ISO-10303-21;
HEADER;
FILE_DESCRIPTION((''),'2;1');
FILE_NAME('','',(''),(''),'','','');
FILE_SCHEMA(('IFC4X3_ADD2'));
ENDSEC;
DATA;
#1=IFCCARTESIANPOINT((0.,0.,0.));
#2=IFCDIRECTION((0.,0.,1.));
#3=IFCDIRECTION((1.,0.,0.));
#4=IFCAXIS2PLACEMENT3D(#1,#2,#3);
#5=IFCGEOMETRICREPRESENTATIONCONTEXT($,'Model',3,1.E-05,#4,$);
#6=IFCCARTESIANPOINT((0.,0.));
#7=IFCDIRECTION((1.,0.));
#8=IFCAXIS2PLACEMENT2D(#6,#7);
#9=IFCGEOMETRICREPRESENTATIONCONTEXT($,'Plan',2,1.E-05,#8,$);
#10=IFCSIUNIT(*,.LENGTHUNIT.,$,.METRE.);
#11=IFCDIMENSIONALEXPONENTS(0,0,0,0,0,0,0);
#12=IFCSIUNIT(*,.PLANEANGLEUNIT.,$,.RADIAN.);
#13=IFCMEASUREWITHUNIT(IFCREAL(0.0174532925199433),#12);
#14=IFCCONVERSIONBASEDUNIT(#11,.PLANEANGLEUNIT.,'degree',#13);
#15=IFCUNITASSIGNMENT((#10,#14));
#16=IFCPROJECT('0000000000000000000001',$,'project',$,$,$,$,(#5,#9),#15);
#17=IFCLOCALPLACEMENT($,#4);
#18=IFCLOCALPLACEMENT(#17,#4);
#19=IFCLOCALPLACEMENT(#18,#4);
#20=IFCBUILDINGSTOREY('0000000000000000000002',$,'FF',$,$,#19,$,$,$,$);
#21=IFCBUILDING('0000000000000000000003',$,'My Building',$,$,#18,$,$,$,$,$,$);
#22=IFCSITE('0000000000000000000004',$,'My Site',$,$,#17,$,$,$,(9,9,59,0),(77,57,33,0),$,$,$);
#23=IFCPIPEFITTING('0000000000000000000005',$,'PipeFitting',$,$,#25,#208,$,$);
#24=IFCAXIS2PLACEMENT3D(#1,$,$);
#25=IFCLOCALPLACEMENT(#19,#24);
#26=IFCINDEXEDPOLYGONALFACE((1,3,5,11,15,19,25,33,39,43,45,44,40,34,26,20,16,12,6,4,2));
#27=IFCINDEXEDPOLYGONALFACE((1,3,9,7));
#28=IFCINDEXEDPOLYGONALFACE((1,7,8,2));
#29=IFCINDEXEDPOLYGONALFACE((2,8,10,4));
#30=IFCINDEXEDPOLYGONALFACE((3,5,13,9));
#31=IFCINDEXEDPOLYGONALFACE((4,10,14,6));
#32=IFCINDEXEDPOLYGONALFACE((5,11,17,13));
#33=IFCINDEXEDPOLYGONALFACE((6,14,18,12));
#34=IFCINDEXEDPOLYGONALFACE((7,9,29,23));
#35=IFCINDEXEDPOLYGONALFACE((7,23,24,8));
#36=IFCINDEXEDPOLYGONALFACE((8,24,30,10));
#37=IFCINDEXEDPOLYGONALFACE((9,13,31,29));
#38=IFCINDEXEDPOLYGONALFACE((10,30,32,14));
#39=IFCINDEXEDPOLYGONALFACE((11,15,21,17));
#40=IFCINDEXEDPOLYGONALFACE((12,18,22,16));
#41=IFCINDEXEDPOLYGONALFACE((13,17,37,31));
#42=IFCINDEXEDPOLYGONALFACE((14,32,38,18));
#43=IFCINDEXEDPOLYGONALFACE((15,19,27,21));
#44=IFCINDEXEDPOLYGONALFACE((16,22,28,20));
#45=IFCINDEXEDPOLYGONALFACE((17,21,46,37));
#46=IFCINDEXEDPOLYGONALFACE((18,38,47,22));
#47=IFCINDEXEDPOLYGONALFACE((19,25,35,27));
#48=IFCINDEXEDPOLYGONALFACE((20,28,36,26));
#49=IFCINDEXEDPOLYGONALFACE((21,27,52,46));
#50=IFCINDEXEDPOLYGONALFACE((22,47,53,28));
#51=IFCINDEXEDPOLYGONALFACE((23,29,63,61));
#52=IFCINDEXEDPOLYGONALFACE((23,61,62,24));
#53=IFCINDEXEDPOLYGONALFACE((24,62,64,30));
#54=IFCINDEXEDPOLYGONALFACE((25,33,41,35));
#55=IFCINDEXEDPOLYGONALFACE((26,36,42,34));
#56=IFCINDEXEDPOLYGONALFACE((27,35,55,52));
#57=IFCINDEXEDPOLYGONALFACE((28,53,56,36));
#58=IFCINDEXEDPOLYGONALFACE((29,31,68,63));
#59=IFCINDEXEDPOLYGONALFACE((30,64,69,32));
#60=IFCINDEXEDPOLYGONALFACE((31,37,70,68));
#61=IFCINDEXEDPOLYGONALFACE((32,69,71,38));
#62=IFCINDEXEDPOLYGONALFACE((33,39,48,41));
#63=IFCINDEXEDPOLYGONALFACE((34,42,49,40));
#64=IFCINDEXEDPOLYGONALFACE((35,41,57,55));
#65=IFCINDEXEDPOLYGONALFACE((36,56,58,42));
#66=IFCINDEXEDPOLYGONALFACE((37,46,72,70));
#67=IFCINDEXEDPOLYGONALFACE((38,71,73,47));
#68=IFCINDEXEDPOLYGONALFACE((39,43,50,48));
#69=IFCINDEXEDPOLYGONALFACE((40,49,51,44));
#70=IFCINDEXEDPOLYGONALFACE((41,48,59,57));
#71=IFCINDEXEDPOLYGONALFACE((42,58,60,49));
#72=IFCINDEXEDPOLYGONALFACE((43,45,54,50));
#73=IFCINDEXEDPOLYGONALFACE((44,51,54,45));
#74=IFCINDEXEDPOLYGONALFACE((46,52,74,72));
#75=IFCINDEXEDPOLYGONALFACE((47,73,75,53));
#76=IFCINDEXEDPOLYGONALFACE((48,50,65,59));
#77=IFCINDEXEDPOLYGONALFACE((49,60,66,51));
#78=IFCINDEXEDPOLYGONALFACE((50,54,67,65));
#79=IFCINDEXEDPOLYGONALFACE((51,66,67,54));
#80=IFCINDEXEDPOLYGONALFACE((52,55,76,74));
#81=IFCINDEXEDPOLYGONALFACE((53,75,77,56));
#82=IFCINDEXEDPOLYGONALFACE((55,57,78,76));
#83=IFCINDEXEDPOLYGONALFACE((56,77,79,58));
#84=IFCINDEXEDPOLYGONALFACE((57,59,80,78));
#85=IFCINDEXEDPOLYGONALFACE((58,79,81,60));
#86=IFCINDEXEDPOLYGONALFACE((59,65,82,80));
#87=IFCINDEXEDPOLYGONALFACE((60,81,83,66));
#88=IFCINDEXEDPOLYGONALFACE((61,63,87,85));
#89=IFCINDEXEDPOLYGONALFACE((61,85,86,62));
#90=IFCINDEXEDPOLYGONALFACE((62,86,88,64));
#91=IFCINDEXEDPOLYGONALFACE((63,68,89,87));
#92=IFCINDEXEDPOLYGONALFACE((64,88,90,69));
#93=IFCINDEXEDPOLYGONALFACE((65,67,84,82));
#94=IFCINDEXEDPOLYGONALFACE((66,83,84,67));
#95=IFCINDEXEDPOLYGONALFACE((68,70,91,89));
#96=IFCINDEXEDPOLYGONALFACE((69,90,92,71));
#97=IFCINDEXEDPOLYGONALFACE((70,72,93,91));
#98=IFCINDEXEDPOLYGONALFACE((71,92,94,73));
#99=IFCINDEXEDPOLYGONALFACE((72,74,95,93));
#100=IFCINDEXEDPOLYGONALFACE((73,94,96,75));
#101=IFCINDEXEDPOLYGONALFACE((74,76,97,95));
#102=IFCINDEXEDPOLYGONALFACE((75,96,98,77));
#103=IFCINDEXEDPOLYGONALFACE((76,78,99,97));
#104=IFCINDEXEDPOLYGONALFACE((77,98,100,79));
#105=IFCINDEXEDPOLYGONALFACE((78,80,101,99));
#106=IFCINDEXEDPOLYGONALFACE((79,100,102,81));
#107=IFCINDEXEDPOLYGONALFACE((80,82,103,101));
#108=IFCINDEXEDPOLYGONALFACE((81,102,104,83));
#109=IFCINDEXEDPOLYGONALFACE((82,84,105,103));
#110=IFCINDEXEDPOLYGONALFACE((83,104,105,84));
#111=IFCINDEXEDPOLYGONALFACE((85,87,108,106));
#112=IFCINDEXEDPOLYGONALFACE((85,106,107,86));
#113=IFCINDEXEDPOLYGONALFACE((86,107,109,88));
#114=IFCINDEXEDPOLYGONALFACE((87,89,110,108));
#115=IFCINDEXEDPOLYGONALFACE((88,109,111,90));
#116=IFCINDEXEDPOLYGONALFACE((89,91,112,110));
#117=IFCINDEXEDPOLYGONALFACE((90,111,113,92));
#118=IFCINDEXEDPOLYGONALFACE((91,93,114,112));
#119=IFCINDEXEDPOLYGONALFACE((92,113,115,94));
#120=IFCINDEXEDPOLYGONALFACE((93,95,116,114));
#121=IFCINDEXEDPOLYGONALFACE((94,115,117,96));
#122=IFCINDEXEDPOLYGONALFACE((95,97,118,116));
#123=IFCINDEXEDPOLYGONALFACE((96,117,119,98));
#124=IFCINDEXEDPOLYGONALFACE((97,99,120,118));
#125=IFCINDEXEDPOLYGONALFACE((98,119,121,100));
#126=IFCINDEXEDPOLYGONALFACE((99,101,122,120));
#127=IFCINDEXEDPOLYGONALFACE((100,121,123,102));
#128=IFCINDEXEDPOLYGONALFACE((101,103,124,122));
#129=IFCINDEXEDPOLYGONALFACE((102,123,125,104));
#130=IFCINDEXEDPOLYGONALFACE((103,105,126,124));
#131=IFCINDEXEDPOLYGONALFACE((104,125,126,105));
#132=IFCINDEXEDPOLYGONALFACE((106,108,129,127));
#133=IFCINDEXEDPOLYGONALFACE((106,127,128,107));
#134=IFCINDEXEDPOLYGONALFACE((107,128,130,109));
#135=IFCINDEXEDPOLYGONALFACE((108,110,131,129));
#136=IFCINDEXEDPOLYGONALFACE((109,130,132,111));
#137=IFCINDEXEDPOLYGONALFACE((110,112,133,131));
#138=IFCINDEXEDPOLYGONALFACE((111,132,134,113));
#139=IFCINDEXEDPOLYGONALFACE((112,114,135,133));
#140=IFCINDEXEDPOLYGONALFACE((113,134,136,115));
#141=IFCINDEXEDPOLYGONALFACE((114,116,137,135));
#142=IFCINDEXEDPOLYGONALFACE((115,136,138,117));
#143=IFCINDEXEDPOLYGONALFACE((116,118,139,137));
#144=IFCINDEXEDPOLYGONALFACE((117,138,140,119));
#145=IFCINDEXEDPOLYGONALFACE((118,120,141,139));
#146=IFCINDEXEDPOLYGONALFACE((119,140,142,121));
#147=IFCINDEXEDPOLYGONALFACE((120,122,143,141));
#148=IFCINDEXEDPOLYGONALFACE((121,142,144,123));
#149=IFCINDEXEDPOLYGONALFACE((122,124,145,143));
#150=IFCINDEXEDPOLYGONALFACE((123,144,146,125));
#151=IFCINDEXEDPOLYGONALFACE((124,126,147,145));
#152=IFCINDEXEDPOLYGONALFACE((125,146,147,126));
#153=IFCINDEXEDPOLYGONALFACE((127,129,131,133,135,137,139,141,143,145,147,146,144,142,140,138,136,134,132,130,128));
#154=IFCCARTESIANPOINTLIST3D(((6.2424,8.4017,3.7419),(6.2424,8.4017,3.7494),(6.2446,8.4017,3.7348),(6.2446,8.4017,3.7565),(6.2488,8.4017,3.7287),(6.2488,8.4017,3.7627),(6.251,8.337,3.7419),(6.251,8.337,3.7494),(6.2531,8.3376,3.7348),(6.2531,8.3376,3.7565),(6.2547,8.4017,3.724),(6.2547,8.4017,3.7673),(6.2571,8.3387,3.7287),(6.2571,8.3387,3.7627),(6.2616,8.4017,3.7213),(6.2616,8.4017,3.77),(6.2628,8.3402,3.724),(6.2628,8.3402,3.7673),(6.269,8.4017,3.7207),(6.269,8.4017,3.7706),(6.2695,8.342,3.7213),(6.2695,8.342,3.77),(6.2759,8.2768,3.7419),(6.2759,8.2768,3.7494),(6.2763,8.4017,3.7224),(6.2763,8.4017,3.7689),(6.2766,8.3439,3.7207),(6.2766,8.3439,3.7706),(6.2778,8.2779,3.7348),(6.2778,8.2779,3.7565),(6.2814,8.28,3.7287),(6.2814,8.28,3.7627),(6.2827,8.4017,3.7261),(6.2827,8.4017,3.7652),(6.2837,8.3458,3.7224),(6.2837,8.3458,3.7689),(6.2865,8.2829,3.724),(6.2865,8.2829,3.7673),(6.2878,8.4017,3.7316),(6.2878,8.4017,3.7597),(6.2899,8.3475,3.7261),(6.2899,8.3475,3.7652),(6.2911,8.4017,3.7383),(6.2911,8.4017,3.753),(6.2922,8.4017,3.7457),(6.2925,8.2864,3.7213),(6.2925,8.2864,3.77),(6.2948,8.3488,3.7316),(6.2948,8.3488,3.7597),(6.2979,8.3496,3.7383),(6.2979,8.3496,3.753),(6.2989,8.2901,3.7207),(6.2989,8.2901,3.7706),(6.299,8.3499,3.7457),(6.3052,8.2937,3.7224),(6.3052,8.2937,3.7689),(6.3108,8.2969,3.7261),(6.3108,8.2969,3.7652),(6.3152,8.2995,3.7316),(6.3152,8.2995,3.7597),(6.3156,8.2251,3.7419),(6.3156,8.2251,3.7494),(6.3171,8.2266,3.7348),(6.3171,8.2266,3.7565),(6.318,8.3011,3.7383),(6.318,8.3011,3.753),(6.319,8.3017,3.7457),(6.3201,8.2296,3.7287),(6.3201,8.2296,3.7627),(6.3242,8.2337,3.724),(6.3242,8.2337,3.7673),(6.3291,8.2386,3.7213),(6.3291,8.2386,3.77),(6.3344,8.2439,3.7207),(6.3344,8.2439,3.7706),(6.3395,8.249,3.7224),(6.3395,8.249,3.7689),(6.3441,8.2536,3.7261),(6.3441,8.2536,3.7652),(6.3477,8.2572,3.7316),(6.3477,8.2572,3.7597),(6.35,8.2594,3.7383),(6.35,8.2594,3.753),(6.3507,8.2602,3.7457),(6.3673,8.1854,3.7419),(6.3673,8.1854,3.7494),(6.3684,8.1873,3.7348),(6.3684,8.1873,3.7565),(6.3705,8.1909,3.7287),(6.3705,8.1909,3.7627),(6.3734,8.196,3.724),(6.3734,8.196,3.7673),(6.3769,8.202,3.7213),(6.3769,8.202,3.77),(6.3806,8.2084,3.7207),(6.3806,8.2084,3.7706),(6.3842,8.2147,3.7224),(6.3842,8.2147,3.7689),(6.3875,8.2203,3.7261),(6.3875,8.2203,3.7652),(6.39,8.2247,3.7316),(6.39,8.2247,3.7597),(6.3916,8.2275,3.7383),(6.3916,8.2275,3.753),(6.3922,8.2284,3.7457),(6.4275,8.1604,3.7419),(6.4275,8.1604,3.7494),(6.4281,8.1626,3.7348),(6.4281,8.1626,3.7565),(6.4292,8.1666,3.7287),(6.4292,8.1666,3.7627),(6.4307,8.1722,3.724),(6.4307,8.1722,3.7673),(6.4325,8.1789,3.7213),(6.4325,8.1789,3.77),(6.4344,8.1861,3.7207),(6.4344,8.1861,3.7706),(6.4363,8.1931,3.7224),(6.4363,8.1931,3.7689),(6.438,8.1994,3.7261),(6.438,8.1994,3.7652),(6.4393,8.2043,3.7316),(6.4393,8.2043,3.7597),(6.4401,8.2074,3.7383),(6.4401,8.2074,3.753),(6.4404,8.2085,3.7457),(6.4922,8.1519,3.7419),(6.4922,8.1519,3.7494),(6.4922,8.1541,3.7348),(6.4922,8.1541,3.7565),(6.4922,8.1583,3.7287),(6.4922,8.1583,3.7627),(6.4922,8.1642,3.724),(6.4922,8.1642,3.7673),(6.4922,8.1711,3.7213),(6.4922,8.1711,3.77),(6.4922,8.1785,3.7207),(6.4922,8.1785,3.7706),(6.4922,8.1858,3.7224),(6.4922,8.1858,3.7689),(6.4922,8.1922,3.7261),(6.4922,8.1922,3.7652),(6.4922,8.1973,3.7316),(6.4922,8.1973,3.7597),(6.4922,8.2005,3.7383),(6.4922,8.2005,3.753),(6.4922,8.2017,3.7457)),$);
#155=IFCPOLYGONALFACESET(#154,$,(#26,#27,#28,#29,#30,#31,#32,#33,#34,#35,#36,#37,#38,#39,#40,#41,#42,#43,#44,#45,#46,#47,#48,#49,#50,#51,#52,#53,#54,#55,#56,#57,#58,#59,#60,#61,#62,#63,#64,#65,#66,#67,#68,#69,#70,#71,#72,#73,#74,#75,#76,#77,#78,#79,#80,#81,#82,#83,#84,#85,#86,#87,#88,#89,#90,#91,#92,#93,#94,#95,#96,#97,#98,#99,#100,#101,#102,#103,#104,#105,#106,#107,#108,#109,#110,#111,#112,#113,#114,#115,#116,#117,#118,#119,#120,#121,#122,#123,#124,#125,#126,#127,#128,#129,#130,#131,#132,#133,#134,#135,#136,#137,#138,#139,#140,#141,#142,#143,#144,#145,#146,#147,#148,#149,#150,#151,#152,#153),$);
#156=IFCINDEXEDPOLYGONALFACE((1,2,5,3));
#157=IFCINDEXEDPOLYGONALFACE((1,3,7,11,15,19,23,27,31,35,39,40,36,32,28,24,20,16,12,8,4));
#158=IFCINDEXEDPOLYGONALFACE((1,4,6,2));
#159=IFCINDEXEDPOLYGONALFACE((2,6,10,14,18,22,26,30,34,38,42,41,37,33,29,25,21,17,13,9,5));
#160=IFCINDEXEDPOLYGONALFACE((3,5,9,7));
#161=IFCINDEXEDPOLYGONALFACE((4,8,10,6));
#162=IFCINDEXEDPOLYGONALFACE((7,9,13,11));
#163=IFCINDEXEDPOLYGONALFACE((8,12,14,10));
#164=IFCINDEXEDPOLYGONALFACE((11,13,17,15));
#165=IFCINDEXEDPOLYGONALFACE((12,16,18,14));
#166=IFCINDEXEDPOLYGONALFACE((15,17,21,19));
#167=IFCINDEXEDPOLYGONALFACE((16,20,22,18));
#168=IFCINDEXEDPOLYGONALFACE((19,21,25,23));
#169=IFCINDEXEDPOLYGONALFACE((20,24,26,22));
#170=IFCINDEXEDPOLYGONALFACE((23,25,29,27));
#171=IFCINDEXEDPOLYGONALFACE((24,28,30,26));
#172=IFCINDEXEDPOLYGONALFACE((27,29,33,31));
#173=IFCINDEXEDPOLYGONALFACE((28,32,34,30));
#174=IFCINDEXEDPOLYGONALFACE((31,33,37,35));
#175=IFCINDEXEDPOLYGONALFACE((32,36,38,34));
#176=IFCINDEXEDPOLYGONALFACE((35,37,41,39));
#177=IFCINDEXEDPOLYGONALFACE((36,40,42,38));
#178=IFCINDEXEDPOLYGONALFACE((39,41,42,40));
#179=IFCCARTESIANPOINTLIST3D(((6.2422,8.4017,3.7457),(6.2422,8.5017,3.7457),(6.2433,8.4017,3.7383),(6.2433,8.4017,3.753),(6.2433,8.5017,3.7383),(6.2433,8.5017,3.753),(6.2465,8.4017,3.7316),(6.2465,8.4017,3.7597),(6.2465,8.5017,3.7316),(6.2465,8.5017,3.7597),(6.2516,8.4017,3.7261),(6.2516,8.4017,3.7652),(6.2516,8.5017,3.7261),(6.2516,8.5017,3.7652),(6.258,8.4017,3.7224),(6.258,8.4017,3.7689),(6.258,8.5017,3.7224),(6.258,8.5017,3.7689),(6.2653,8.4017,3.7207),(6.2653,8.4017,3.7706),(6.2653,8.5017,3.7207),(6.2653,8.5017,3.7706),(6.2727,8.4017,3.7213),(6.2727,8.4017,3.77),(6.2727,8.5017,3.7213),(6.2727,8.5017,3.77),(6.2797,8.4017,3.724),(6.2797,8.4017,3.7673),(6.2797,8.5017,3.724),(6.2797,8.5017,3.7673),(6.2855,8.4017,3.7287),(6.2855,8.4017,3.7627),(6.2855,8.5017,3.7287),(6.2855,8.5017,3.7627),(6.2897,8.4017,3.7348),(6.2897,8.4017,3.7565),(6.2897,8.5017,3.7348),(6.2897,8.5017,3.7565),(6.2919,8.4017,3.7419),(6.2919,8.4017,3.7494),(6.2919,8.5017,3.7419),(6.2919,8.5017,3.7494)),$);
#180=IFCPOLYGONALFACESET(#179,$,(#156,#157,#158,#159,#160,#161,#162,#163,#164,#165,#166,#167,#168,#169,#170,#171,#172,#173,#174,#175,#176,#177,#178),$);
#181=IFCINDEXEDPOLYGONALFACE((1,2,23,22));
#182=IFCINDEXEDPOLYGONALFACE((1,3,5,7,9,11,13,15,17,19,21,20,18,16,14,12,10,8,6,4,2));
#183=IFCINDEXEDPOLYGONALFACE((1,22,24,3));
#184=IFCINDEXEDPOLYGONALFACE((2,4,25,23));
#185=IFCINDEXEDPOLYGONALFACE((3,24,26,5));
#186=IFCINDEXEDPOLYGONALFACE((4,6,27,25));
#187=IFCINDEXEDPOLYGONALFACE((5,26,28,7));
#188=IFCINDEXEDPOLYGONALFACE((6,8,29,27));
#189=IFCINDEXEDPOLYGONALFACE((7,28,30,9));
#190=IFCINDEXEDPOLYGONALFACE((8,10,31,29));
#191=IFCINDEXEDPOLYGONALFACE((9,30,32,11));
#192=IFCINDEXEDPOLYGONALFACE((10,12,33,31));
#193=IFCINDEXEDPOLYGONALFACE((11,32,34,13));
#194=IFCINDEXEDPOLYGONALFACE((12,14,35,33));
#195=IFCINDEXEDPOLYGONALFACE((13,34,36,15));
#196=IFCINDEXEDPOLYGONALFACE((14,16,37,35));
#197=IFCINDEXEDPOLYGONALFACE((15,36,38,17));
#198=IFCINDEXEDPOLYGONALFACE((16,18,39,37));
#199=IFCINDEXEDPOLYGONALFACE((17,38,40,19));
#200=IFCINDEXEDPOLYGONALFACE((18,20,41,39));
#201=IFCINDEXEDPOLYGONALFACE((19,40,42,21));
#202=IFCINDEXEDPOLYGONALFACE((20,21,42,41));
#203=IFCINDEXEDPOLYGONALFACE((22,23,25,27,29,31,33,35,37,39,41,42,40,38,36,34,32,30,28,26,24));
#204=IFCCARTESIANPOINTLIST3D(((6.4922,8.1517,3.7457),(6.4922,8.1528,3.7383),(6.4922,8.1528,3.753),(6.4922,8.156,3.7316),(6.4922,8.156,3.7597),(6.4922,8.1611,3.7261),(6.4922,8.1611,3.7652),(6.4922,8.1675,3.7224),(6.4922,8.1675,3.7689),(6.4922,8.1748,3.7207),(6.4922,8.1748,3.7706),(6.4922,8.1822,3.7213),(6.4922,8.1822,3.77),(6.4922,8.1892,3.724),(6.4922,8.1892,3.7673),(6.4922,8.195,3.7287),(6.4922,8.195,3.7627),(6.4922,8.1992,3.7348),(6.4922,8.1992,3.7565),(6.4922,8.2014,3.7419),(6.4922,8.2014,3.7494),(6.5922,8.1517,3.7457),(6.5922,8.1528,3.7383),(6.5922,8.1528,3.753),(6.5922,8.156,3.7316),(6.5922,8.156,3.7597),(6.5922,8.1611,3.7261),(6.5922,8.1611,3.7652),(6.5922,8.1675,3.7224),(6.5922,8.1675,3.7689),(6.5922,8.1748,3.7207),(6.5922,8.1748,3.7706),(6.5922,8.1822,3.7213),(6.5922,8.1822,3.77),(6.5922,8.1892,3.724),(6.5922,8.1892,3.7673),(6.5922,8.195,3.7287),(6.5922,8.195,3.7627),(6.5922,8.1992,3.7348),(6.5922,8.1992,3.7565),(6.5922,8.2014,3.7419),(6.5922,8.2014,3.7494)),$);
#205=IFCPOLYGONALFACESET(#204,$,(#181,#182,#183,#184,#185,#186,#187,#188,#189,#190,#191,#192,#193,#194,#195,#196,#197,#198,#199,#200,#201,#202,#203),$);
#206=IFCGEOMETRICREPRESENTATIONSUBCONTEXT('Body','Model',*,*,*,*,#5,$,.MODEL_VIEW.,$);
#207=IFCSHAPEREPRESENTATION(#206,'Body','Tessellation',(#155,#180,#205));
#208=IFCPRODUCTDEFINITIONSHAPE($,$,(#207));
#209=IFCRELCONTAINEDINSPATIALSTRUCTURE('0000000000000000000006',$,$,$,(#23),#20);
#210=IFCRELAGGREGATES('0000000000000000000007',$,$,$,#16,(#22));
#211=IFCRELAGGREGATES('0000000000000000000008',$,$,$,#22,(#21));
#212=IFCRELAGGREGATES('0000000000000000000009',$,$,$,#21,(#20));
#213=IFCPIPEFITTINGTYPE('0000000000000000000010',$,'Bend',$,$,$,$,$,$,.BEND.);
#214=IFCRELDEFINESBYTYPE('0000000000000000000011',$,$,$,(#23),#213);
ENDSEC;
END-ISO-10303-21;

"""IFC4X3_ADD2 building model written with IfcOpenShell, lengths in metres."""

from ifc_helpers import new_model, entity, si_unit, converted_unit, frame, origin_with_axes, origin_2d_with_axis, place, context, subcontext, project, spatial, circle, extrude, source, transform, mapped, type_object, type_shapes, element, save


model = new_model("IFC4X3_ADD2")

# Units and contexts
model_context = context("Model", 3, precision=1e-05, world=origin_with_axes())
plan_context = context("Plan", 2, precision=1e-05, world=origin_2d_with_axis())
body_context_1 = subcontext(model_context, "Body", "Model", "MODEL_VIEW")
ifc_project = project(units=[si_unit("LENGTHUNIT", "METRE"), converted_unit("PLANEANGLEUNIT", "degree", entity("IfcReal", 0.0174532925199433), si_unit("PLANEANGLEUNIT", "RADIAN"), dimensions=[0, 0, 0, 0, 0, 0, 0])], contexts=[model_context, plan_context])

# Site, building, storey
site_placement = place(None, origin_with_axes())
site = spatial("IfcSite", under=ifc_project, at=site_placement, Name="My Site", RefLatitude=(9, 9, 59, 0), RefLongitude=(77, 57, 33, 0))
building_placement = place(site_placement, origin_with_axes())
building = spatial("IfcBuilding", under=site, at=building_placement, Name="My Building")
storey_placement = place(building_placement, origin_with_axes())
storey = spatial("IfcBuildingStorey", under=building, at=storey_placement, Name="FF")

# Pipe fitting
pipe_fitting_type_1 = type_object("IfcPipeFittingType", Name="Bend", PredefinedType="BEND")
shared_shape_1 = source(origin_with_axes(), body_context_1, "Body", "SolidModel", [
    entity("IfcSweptDiskSolid", entity("IfcIndexedPolyCurve", entity("IfcCartesianPointList3D", [[0.0, 0.0, -0.1], [-0.0659, 0.0, -0.2591], [-0.225, 0.0, -0.325]]), [entity("IfcArcIndex", [1, 2, 3])]), 0.025),
    extrude(circle(Radius=0.025), origin_with_axes(), (0.0, 0.0, -1.0), 0.1),
    extrude(circle(Radius=0.025), frame((-0.225, 0.0, -0.325), z_axis=(-1.0, 0.0, 0.0), x_axis=(0.0, 0.0, -1.0)), (0.0, 0.0, 1.0), 0.1),
])
type_shapes(pipe_fitting_type_1, [shared_shape_1])
pipe_fitting_1_placement = place(storey_placement, frame((6.2672, 8.5017, 3.7457), z_axis=(0.0, 1.0, 0.0), x_axis=(-1.0, 0.0, 0.0)))
element("IfcPipeFitting", 1, at=pipe_fitting_1_placement, inside=storey, type_object=pipe_fitting_type_1, Name="PipeFitting", context=body_context_1, shape_type="MappedRepresentation", body=[
    mapped(shared_shape_1, transform((0.0, 0.0, 0.0), x_axis=(1.0, 0.0, 0.0), y_axis=(0.0, 1.0, 0.0), z_axis=(0.0, 0.0, 1.0), scale=1.0)),
])

save(model, "model.ifc")
